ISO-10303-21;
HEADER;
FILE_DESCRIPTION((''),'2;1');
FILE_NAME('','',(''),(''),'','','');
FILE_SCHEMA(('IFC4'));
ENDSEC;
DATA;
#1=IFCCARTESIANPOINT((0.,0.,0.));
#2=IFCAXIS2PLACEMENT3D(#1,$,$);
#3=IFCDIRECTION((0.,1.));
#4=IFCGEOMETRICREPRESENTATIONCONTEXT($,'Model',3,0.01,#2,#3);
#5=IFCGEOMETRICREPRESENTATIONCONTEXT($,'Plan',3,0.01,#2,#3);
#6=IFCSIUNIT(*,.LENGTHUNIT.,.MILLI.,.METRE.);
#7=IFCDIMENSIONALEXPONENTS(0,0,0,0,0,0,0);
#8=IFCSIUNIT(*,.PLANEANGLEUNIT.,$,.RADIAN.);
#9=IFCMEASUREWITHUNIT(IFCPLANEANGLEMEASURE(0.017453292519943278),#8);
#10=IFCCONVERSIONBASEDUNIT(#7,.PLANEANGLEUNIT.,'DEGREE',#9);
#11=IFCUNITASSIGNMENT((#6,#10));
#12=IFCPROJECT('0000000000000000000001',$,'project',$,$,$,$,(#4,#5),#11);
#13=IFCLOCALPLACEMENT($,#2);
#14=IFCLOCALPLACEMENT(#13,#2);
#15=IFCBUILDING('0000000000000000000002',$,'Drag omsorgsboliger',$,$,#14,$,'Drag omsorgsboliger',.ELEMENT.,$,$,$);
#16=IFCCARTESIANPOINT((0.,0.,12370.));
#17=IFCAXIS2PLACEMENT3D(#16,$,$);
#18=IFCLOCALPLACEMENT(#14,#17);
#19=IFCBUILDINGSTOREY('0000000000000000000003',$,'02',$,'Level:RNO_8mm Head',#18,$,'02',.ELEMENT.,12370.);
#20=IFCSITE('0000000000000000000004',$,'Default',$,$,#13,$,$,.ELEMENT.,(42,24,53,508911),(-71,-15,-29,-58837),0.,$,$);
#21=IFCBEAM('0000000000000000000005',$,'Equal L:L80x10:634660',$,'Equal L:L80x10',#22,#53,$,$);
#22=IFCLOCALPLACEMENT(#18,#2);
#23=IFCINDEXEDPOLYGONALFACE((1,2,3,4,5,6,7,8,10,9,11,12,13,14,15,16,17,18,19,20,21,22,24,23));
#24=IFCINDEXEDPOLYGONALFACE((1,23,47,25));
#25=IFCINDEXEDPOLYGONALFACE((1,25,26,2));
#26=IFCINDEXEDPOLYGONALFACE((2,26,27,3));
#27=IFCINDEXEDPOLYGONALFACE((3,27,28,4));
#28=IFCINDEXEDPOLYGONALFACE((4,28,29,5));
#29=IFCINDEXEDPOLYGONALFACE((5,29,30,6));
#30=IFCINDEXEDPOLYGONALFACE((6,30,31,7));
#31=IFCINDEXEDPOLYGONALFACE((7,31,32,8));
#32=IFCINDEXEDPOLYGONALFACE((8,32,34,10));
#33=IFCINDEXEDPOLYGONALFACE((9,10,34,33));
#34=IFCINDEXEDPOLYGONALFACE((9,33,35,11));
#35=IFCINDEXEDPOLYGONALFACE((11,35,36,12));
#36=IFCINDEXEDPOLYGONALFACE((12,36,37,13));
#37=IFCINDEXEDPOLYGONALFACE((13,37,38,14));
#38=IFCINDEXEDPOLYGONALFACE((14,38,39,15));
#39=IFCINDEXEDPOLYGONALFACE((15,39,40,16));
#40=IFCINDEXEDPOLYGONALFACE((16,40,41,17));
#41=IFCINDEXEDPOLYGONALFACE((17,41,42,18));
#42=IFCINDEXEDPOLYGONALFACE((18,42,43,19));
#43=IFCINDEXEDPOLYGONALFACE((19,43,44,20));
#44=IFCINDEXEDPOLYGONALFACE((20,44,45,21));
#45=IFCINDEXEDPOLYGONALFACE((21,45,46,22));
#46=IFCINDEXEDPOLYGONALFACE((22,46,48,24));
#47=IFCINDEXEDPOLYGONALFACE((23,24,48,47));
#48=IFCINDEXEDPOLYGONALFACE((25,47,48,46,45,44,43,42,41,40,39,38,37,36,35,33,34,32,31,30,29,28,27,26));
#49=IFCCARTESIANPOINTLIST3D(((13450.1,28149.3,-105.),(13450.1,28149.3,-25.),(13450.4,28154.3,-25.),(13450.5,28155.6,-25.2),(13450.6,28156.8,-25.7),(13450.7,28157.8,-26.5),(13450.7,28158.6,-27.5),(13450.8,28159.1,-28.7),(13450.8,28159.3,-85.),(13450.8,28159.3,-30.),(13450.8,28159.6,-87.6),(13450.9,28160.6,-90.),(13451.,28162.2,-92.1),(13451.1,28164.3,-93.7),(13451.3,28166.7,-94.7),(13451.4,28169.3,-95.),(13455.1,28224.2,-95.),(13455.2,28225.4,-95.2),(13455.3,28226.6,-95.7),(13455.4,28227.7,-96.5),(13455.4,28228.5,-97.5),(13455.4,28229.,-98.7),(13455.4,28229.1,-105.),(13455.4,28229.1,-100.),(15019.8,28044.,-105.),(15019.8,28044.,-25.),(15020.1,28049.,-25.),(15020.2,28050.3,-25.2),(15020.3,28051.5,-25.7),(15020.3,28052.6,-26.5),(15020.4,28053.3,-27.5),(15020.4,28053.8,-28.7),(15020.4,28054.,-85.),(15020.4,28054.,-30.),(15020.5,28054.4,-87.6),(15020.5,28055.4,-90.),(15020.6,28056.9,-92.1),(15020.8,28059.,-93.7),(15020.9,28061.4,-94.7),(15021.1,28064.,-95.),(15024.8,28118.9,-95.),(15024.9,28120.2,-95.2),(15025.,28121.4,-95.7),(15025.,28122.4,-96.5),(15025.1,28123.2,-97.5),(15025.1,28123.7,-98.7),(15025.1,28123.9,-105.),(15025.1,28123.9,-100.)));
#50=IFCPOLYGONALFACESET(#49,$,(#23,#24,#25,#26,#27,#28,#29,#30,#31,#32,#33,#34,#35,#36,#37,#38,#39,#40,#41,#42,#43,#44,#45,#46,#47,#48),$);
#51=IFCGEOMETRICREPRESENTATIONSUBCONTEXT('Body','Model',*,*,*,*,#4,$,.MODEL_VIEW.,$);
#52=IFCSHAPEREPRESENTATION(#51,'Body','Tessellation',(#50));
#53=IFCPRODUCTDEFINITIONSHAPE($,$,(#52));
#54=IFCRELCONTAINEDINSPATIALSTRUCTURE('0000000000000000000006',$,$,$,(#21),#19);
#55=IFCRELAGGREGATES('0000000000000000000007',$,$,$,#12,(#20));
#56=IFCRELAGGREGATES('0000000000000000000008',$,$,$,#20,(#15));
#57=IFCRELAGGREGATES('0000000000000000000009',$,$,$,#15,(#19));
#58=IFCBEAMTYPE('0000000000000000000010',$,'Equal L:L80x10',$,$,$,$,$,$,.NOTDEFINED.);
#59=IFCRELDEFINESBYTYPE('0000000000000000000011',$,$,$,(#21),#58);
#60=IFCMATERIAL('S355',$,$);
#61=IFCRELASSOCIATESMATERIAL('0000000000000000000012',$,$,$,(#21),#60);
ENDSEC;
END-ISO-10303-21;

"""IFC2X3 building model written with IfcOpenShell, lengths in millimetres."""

from ifc_helpers import new_model, entity, si_unit, converted_unit, direction, frame, frame_2d, origin, place, context, subcontext, project, spatial, polyline, circle_curve, parameter, trimmed, segment, composite_curve, outline, extrude, material, type_object, element, save


model = new_model("IFC2X3")

# Units and contexts
model_context = context("Model", 3, precision=0.01, world=origin(), true_north=direction((0.0, 1.0)))
plan_context = context("Plan", 3, precision=0.01, world=origin(), true_north=direction((0.0, 1.0)))
body_context = subcontext(model_context, "Body", "Model", "MODEL_VIEW")
ifc_project = project(units=[si_unit("LENGTHUNIT", "METRE", prefix="MILLI"), converted_unit("PLANEANGLEUNIT", "DEGREE", entity("IfcPlaneAngleMeasure", 0.017453292519943278), si_unit("PLANEANGLEUNIT", "RADIAN"), dimensions=[0, 0, 0, 0, 0, 0, 0])], contexts=[model_context, plan_context])

# Site, building, storey
site_placement = place(None, origin())
site = spatial("IfcSite", under=ifc_project, at=site_placement, Name="Default", CompositionType="ELEMENT", RefLatitude=(42, 24, 53, 508911), RefLongitude=(-71, -15, -29, -58837), RefElevation=0.0)
building_placement = place(site_placement, origin())
building = spatial("IfcBuilding", under=site, at=building_placement, Name="Drag omsorgsboliger", LongName="Drag omsorgsboliger", CompositionType="ELEMENT")
storey_placement = place(building_placement, frame((0.0, 0.0, 12370.0)))
storey = spatial("IfcBuildingStorey", under=building, at=storey_placement, Name="02", ObjectType="Level:RNO_8mm Head", LongName="02", CompositionType="ELEMENT", Elevation=12370.0)

# Beam
ifc_material = material(Name="S355")
beam_type_1 = type_object("IfcBeamType", Name="Equal L:L80x10", PredefinedType="NOTDEFINED")
beam_1_placement = place(storey_placement, frame((15181.1, 28056.7, -25.0), z_axis=(0.0, 0.0, 1.0), x_axis=(-0.997758, 0.066923, 0.0)))
element("IfcBeam", 1, at=beam_1_placement, inside=storey, type_object=beam_type_1, material=ifc_material, Name="Equal L:L80x10:634660", ObjectType="Equal L:L80x10", context=body_context, shape_type="SweptSolid", body=[
    extrude(outline(composite_curve([segment(polyline([(26.1, -48.9), (31.1, -48.9)]), True, "CONTINUOUS"), segment(polyline([(31.1, -48.9), (31.1, 31.1)]), True, "CONTINUOUS"), segment(polyline([(31.1, 31.1), (-48.9, 31.1)]), True, "CONTINUOUS"), segment(polyline([(-48.9, 31.1), (-48.9, 26.1)]), True, "CONTINUOUS"), segment(trimmed(circle_curve(frame_2d((-43.9, 26.1), x_axis=(-1.0, 0.0)), 5.0), [parameter(0.0)], [parameter(90.0)], True, "PARAMETER"), True, "CONTINUOUS"), segment(polyline([(-43.9, 21.1), (11.1, 21.1)]), True, "CONTINUOUS"), segment(trimmed(circle_curve(frame_2d((11.1, 11.1), x_axis=(0.0, 1.0)), 10.0), [parameter(270.0)], [parameter(0.0)], True, "PARAMETER"), False, "CONTINUOUS"), segment(polyline([(21.1, 11.1), (21.1, -43.9)]), True, "CONTINUOUS"), segment(trimmed(circle_curve(frame_2d((26.1, -43.9), x_axis=(-1.0, 0.0)), 5.0), [parameter(0.0)], [parameter(90.0)], True, "PARAMETER"), True, "CONTINUOUS")], self_intersect=False)), frame((160.1, -7.7, -48.9), z_axis=(1.0, 0.0, 0.0), x_axis=(0.0, 0.0, -1.0)), (0.0, 0.0, 1.0), 1573.2),
])

save(model, "model.ifc")
